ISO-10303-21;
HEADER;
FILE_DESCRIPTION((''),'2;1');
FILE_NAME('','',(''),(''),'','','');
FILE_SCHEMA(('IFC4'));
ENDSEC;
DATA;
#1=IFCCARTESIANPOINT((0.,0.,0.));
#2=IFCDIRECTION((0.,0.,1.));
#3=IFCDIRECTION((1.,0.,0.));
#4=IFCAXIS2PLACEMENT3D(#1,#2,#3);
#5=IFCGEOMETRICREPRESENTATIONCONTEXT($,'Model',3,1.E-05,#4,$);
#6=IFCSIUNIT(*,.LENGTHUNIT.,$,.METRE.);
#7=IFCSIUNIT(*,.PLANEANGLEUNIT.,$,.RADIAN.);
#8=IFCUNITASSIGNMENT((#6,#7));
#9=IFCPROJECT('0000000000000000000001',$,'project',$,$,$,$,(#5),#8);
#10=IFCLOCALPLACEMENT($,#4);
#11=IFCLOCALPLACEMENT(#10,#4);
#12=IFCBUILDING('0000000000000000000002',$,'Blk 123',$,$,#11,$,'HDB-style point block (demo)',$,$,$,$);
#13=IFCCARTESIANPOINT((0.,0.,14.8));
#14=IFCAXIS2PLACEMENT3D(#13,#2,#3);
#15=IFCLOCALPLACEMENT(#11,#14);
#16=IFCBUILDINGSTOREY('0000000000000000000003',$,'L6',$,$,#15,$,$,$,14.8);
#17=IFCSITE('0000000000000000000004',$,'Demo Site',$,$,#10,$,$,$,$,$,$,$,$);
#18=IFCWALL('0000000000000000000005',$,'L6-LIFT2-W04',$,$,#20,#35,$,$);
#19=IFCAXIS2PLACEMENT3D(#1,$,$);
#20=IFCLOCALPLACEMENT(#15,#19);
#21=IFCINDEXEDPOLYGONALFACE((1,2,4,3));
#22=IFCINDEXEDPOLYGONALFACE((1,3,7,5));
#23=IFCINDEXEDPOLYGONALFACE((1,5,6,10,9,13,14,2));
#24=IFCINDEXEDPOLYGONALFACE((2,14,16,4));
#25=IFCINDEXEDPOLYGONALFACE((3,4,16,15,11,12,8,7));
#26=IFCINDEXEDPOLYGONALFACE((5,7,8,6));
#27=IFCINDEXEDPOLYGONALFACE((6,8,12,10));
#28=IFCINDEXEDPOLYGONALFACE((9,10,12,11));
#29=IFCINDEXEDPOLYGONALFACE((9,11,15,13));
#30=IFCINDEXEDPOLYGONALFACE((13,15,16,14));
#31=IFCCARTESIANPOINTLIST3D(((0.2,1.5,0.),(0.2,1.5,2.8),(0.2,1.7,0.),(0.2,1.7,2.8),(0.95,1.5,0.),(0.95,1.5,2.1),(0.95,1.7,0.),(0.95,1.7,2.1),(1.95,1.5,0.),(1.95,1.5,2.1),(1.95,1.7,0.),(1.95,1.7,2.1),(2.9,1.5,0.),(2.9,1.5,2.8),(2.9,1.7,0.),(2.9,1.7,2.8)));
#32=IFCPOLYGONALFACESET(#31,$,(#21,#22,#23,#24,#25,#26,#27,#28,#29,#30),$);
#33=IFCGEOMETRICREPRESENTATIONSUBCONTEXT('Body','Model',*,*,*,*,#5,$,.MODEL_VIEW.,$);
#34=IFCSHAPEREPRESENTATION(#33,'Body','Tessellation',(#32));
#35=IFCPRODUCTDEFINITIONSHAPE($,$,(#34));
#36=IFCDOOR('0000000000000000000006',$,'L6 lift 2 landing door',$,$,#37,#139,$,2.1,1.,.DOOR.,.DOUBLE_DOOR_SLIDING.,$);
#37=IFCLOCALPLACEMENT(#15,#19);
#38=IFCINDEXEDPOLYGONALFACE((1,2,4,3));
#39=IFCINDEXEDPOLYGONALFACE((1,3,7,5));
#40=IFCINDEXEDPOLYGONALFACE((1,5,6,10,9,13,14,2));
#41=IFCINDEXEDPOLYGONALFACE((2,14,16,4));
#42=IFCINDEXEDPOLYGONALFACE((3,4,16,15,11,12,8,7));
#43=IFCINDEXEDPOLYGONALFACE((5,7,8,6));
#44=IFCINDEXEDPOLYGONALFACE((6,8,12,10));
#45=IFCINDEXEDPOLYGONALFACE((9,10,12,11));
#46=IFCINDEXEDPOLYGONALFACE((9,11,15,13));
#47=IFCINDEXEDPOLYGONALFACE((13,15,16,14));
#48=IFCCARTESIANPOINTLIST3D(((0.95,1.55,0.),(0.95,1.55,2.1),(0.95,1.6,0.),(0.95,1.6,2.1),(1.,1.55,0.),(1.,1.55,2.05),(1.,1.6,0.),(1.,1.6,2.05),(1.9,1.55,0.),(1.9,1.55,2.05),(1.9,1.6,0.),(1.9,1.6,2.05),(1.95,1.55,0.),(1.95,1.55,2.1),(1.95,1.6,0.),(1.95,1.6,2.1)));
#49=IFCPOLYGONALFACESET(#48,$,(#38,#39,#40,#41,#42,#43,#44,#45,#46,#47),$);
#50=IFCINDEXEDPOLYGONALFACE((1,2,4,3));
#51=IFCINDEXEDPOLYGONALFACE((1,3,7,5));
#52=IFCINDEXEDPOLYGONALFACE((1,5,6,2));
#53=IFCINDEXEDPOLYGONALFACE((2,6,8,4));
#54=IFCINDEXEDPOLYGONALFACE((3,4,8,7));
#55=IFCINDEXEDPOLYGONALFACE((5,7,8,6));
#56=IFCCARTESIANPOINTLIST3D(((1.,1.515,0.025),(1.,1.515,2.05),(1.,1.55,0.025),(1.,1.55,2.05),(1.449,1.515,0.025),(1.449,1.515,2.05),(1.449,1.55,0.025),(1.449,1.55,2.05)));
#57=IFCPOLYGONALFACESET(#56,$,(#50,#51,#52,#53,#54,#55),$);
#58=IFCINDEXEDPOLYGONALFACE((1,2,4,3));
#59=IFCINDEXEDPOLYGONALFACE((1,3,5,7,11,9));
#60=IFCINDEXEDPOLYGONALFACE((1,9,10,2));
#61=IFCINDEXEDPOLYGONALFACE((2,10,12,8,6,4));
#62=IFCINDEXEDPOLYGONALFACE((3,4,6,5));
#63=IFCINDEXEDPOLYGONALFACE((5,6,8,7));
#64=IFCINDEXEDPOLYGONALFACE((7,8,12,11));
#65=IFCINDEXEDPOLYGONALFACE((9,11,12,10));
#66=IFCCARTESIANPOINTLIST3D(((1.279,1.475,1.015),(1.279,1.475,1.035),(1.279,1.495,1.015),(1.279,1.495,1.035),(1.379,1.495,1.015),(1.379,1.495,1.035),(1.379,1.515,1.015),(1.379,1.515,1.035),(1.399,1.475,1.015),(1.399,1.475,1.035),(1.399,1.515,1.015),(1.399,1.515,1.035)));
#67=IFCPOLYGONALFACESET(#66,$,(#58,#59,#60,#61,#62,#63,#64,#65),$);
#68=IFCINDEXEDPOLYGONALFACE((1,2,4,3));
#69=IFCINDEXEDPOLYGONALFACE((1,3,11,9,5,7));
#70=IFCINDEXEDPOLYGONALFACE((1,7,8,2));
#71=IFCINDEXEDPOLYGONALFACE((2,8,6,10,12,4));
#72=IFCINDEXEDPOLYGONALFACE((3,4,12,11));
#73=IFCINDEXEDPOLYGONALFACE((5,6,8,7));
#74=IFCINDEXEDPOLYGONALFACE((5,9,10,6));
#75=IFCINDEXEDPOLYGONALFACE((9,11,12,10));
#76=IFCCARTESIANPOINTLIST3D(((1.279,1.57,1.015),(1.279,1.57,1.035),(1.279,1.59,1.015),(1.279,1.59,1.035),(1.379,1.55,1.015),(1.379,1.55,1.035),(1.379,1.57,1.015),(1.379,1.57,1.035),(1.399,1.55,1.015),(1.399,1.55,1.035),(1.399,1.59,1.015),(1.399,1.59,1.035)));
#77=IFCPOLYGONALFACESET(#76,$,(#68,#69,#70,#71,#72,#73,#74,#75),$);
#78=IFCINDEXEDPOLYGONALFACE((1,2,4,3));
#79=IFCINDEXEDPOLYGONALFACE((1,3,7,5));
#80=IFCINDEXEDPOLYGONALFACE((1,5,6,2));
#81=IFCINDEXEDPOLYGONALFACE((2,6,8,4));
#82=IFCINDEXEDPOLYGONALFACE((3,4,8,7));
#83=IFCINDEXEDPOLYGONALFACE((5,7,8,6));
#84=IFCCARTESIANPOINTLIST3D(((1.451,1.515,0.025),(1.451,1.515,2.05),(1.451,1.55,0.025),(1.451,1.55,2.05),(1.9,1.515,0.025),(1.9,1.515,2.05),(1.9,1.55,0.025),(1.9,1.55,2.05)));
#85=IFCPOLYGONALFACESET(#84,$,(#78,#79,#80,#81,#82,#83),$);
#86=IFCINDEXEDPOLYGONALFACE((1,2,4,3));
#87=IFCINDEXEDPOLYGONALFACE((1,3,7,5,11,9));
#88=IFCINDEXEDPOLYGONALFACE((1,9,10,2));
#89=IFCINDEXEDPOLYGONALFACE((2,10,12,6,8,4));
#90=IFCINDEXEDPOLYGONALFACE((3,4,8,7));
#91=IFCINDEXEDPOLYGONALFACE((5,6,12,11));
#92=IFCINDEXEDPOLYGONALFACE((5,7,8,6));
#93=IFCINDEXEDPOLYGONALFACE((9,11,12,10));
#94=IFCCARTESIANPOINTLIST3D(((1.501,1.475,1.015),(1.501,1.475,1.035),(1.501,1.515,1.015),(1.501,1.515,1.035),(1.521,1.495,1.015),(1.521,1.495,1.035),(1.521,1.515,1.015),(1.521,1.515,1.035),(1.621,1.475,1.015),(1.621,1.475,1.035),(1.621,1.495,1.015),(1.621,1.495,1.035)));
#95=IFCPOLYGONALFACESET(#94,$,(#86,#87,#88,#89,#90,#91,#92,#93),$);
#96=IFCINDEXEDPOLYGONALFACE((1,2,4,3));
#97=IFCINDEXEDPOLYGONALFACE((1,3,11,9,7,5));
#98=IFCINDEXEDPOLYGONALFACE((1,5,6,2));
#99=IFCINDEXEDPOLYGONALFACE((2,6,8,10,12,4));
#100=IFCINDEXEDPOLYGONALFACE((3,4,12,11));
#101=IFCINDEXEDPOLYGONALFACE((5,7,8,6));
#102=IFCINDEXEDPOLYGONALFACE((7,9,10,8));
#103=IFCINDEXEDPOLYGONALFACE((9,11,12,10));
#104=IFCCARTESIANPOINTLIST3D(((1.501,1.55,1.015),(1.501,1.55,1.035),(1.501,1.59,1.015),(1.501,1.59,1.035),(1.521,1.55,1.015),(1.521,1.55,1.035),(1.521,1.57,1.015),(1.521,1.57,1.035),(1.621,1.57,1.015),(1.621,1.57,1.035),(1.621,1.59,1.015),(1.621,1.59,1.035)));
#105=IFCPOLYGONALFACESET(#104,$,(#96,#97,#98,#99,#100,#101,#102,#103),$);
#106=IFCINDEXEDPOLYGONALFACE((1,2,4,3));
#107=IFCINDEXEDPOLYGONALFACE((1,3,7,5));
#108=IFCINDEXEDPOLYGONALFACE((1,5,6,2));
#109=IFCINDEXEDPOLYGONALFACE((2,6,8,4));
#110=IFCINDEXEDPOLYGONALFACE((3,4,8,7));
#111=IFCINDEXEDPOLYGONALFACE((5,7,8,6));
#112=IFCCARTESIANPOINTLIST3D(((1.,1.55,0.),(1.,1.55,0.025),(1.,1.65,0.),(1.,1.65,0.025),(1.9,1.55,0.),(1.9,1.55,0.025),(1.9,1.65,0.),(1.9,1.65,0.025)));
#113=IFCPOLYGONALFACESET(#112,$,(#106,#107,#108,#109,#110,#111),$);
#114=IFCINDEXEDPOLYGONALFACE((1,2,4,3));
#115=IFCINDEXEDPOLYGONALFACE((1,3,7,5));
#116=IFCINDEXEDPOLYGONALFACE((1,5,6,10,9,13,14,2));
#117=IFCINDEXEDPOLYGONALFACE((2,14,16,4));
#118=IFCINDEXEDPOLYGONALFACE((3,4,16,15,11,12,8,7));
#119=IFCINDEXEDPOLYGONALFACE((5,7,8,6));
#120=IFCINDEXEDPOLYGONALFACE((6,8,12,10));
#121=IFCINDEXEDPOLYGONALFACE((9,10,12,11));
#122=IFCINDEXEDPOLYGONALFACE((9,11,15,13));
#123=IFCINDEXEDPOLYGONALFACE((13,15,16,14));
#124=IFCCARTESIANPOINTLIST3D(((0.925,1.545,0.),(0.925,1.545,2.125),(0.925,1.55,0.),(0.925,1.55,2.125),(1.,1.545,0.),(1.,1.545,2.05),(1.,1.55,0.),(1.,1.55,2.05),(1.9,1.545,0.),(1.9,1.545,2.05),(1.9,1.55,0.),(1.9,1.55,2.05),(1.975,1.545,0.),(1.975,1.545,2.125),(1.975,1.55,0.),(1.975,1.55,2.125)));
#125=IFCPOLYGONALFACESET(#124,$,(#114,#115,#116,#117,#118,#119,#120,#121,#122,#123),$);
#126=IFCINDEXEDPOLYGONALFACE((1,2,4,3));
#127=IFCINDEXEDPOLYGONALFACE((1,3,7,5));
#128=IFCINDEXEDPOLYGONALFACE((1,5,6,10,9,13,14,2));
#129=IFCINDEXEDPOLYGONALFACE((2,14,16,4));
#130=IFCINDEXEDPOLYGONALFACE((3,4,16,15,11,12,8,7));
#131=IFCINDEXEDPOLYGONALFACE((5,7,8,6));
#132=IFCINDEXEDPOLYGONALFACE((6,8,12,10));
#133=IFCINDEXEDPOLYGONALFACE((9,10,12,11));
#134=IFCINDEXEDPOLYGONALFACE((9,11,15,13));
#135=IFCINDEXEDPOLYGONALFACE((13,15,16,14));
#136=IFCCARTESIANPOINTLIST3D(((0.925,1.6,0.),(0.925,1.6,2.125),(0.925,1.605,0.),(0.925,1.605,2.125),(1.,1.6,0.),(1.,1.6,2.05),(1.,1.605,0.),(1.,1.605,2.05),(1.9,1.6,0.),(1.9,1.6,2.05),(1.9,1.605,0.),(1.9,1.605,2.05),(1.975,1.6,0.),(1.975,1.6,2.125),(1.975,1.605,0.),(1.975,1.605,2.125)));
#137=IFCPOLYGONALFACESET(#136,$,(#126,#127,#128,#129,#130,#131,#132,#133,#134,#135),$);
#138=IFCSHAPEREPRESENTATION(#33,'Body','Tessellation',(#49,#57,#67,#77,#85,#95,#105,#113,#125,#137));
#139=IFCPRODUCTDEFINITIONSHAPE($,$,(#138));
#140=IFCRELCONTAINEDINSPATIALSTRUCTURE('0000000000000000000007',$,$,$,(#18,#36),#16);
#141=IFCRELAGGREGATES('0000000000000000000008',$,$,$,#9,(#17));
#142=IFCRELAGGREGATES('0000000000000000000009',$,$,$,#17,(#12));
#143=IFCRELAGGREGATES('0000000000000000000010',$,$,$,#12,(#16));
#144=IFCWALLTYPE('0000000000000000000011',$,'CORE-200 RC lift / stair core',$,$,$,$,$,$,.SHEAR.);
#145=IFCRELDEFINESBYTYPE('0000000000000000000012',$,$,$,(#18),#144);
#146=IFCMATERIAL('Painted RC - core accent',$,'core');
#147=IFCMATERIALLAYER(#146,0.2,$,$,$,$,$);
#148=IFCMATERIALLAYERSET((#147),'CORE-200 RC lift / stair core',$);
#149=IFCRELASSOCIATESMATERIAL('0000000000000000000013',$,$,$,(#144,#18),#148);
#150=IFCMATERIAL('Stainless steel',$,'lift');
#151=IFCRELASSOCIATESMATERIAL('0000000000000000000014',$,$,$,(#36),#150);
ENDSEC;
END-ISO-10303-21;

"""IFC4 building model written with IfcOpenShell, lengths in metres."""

from ifc_helpers import new_model, si_unit, frame, origin_with_axes, place, context, subcontext, project, spatial, line, indexed_curve, outline, extrude, material, layer, layer_set, layer_usage, type_object, element, fill, save


model = new_model("IFC4")

# Units and contexts
model_context = context("Model", 3, precision=1e-05, world=origin_with_axes())
body_context = subcontext(model_context, "Body", "Model", "MODEL_VIEW")
ifc_project = project(units=[si_unit("LENGTHUNIT", "METRE"), si_unit("PLANEANGLEUNIT", "RADIAN")], contexts=[model_context])

# Site, building, storey
site_placement = place(None, origin_with_axes())
site = spatial("IfcSite", under=ifc_project, at=site_placement, Name="Demo Site")
building_placement = place(site_placement, origin_with_axes())
building = spatial("IfcBuilding", under=site, at=building_placement, Name="Blk 123", LongName="HDB-style point block (demo)")
storey_placement = place(building_placement, frame((0.0, 0.0, 14.8), z_axis=(0.0, 0.0, 1.0), x_axis=(1.0, 0.0, 0.0)))
storey = spatial("IfcBuildingStorey", under=building, at=storey_placement, Name="L6", Elevation=14.8)

# Shared definitions
ifc_material_1 = material(Name="Painted RC - core accent", Category="core")
ifc_layer_1 = layer(ifc_material_1, 0.2)
ifc_layer_set_1 = layer_set([ifc_layer_1], Name="CORE-200 RC lift / stair core")
ifc_layer_usage_1 = layer_usage(ifc_layer_set_1, "AXIS2", "POSITIVE", 0.0)
wall_type_1 = type_object("IfcWallType", Name="CORE-200 RC lift / stair core", PredefinedType="SHEAR", material=ifc_layer_set_1)

# Wall, opening, door
wall_1_placement = place(storey_placement, frame((0.2, 1.5, 0.0), z_axis=(0.0, 0.0, 1.0), x_axis=(1.0, 0.0, 0.0)))
wall_1 = element("IfcWall", 1, at=wall_1_placement, inside=storey, type_object=wall_type_1, material=ifc_layer_usage_1, Name="L6-LIFT2-W04", context=body_context, shape_type="SweptSolid", body=[
    extrude(outline(indexed_curve([(0.0, 0.0), (0.0, 0.2), (2.7, 0.2), (2.7, 0.0), (0.0, 0.0)], self_intersect=False)), origin_with_axes(), (0.0, 0.0, 1.0), 2.8),
])
opening_1_placement = place(wall_1_placement, frame((0.75, -0.1, 0.0), z_axis=(0.0, 0.0, 1.0), x_axis=(1.0, 0.0, 0.0)))
opening_1 = element("IfcOpeningElement", 2, at=opening_1_placement, cuts=wall_1, context=body_context, shape_type="SweptSolid", body=[
    extrude(outline(indexed_curve([(0.0, 0.0), (0.0, 0.4), (1.0, 0.4), (1.0, 0.0), (0.0, 0.0)], self_intersect=False)), origin_with_axes(), (0.0, 0.0, 1.0), 2.1),
])
ifc_material_2 = material(Name="Stainless steel", Category="lift")
door_1_placement = place(opening_1_placement, frame((0.0, 0.15, 0.0), z_axis=(0.0, 0.0, 1.0), x_axis=(1.0, 0.0, 0.0)))
door_1 = element("IfcDoor", 3, at=door_1_placement, inside=storey, material=ifc_material_2, Name="L6 lift 2 landing door", OperationType="DOUBLE_DOOR_SLIDING", OverallHeight=2.1, OverallWidth=1.0, PredefinedType="DOOR", context=body_context, shape_type="SweptSolid", body=[
    extrude(outline(indexed_curve([(0.0, 0.0), (0.0, 2.1), (1.0, 2.1), (1.0, 0.0), (0.95, 0.0), (0.95, 2.05), (0.05, 2.05), (0.05, 0.0)], segments=[line(1, 2, 3, 4, 5, 6, 7, 8, 1)])), frame((0.0, 0.0, 0.0), z_axis=(0.0, -1.0, 0.0), x_axis=(1.0, 0.0, 0.0)), (0.0, 0.0, -1.0), 0.05),
    extrude(outline(indexed_curve([(0.0, 0.0), (0.449, 0.0), (0.449, 0.035), (0.0, 0.035)], segments=[line(1, 2, 3, 4, 1)])), frame((0.05, -0.035, 0.025), z_axis=(0.0, 0.0, 1.0), x_axis=(1.0, 0.0, 0.0)), (0.0, 0.0, 1.0), 2.025),
    extrude(outline(indexed_curve([(0.0, 0.0), (0.0, -0.04), (-0.12, -0.04), (-0.12, -0.02), (-0.02, -0.02), (-0.02, 0.0)], segments=[line(1, 2, 3, 4, 5, 6, 1)])), frame((0.449, -0.035, 1.015), z_axis=(0.0, 0.0, 1.0), x_axis=(1.0, 0.0, 0.0)), (0.0, 0.0, 1.0), 0.02),
    extrude(outline(indexed_curve([(0.0, 0.0), (0.0, 0.04), (-0.12, 0.04), (-0.12, 0.02), (-0.02, 0.02), (-0.02, 0.0)], segments=[line(1, 2, 3, 4, 5, 6, 1)])), frame((0.449, 0.0, 1.015), z_axis=(0.0, 0.0, 1.0), x_axis=(1.0, 0.0, 0.0)), (0.0, 0.0, 1.0), 0.02),
    extrude(outline(indexed_curve([(0.0, 0.0), (-0.449, 0.0), (-0.449, 0.035), (0.0, 0.035)], segments=[line(1, 2, 3, 4, 1)])), frame((0.95, -0.035, 0.025), z_axis=(0.0, 0.0, 1.0), x_axis=(1.0, 0.0, 0.0)), (0.0, 0.0, 1.0), 2.025),
    extrude(outline(indexed_curve([(0.0, 0.0), (0.0, -0.04), (0.12, -0.04), (0.12, -0.02), (0.02, -0.02), (0.02, 0.0)], segments=[line(1, 2, 3, 4, 5, 6, 1)])), frame((0.551, -0.035, 1.015), z_axis=(0.0, 0.0, 1.0), x_axis=(1.0, 0.0, 0.0)), (0.0, 0.0, 1.0), 0.02),
    extrude(outline(indexed_curve([(0.0, 0.0), (0.0, 0.04), (0.12, 0.04), (0.12, 0.02), (0.02, 0.02), (0.02, 0.0)], segments=[line(1, 2, 3, 4, 5, 6, 1)])), frame((0.551, 0.0, 1.015), z_axis=(0.0, 0.0, 1.0), x_axis=(1.0, 0.0, 0.0)), (0.0, 0.0, 1.0), 0.02),
    extrude(outline(indexed_curve([(0.0, 0.0), (0.9, 0.0), (0.9, 0.1), (0.0, 0.1)], segments=[line(1, 2, 3, 4, 1)])), frame((0.05, 0.0, 0.0), z_axis=(0.0, 0.0, 1.0), x_axis=(1.0, 0.0, 0.0)), (0.0, 0.0, 1.0), 0.025),
    extrude(outline(indexed_curve([(0.0, 0.0), (0.0, 2.125), (1.05, 2.125), (1.05, 0.0), (0.975, 0.0), (0.975, 2.05), (0.075, 2.05), (0.075, 0.0)], segments=[line(1, 2, 3, 4, 5, 6, 7, 8, 1)])), frame((-0.025, -0.005, 0.0), z_axis=(0.0, -1.0, 0.0), x_axis=(1.0, 0.0, 0.0)), (0.0, 0.0, -1.0), 0.005),
    extrude(outline(indexed_curve([(0.0, 0.0), (0.0, 2.125), (1.05, 2.125), (1.05, 0.0), (0.975, 0.0), (0.975, 2.05), (0.075, 2.05), (0.075, 0.0)], segments=[line(1, 2, 3, 4, 5, 6, 7, 8, 1)])), frame((-0.025, 0.05, 0.0), z_axis=(0.0, -1.0, 0.0), x_axis=(1.0, 0.0, 0.0)), (0.0, 0.0, -1.0), 0.005),
])
fill(opening_1, door_1)

save(model, "model.ifc")
